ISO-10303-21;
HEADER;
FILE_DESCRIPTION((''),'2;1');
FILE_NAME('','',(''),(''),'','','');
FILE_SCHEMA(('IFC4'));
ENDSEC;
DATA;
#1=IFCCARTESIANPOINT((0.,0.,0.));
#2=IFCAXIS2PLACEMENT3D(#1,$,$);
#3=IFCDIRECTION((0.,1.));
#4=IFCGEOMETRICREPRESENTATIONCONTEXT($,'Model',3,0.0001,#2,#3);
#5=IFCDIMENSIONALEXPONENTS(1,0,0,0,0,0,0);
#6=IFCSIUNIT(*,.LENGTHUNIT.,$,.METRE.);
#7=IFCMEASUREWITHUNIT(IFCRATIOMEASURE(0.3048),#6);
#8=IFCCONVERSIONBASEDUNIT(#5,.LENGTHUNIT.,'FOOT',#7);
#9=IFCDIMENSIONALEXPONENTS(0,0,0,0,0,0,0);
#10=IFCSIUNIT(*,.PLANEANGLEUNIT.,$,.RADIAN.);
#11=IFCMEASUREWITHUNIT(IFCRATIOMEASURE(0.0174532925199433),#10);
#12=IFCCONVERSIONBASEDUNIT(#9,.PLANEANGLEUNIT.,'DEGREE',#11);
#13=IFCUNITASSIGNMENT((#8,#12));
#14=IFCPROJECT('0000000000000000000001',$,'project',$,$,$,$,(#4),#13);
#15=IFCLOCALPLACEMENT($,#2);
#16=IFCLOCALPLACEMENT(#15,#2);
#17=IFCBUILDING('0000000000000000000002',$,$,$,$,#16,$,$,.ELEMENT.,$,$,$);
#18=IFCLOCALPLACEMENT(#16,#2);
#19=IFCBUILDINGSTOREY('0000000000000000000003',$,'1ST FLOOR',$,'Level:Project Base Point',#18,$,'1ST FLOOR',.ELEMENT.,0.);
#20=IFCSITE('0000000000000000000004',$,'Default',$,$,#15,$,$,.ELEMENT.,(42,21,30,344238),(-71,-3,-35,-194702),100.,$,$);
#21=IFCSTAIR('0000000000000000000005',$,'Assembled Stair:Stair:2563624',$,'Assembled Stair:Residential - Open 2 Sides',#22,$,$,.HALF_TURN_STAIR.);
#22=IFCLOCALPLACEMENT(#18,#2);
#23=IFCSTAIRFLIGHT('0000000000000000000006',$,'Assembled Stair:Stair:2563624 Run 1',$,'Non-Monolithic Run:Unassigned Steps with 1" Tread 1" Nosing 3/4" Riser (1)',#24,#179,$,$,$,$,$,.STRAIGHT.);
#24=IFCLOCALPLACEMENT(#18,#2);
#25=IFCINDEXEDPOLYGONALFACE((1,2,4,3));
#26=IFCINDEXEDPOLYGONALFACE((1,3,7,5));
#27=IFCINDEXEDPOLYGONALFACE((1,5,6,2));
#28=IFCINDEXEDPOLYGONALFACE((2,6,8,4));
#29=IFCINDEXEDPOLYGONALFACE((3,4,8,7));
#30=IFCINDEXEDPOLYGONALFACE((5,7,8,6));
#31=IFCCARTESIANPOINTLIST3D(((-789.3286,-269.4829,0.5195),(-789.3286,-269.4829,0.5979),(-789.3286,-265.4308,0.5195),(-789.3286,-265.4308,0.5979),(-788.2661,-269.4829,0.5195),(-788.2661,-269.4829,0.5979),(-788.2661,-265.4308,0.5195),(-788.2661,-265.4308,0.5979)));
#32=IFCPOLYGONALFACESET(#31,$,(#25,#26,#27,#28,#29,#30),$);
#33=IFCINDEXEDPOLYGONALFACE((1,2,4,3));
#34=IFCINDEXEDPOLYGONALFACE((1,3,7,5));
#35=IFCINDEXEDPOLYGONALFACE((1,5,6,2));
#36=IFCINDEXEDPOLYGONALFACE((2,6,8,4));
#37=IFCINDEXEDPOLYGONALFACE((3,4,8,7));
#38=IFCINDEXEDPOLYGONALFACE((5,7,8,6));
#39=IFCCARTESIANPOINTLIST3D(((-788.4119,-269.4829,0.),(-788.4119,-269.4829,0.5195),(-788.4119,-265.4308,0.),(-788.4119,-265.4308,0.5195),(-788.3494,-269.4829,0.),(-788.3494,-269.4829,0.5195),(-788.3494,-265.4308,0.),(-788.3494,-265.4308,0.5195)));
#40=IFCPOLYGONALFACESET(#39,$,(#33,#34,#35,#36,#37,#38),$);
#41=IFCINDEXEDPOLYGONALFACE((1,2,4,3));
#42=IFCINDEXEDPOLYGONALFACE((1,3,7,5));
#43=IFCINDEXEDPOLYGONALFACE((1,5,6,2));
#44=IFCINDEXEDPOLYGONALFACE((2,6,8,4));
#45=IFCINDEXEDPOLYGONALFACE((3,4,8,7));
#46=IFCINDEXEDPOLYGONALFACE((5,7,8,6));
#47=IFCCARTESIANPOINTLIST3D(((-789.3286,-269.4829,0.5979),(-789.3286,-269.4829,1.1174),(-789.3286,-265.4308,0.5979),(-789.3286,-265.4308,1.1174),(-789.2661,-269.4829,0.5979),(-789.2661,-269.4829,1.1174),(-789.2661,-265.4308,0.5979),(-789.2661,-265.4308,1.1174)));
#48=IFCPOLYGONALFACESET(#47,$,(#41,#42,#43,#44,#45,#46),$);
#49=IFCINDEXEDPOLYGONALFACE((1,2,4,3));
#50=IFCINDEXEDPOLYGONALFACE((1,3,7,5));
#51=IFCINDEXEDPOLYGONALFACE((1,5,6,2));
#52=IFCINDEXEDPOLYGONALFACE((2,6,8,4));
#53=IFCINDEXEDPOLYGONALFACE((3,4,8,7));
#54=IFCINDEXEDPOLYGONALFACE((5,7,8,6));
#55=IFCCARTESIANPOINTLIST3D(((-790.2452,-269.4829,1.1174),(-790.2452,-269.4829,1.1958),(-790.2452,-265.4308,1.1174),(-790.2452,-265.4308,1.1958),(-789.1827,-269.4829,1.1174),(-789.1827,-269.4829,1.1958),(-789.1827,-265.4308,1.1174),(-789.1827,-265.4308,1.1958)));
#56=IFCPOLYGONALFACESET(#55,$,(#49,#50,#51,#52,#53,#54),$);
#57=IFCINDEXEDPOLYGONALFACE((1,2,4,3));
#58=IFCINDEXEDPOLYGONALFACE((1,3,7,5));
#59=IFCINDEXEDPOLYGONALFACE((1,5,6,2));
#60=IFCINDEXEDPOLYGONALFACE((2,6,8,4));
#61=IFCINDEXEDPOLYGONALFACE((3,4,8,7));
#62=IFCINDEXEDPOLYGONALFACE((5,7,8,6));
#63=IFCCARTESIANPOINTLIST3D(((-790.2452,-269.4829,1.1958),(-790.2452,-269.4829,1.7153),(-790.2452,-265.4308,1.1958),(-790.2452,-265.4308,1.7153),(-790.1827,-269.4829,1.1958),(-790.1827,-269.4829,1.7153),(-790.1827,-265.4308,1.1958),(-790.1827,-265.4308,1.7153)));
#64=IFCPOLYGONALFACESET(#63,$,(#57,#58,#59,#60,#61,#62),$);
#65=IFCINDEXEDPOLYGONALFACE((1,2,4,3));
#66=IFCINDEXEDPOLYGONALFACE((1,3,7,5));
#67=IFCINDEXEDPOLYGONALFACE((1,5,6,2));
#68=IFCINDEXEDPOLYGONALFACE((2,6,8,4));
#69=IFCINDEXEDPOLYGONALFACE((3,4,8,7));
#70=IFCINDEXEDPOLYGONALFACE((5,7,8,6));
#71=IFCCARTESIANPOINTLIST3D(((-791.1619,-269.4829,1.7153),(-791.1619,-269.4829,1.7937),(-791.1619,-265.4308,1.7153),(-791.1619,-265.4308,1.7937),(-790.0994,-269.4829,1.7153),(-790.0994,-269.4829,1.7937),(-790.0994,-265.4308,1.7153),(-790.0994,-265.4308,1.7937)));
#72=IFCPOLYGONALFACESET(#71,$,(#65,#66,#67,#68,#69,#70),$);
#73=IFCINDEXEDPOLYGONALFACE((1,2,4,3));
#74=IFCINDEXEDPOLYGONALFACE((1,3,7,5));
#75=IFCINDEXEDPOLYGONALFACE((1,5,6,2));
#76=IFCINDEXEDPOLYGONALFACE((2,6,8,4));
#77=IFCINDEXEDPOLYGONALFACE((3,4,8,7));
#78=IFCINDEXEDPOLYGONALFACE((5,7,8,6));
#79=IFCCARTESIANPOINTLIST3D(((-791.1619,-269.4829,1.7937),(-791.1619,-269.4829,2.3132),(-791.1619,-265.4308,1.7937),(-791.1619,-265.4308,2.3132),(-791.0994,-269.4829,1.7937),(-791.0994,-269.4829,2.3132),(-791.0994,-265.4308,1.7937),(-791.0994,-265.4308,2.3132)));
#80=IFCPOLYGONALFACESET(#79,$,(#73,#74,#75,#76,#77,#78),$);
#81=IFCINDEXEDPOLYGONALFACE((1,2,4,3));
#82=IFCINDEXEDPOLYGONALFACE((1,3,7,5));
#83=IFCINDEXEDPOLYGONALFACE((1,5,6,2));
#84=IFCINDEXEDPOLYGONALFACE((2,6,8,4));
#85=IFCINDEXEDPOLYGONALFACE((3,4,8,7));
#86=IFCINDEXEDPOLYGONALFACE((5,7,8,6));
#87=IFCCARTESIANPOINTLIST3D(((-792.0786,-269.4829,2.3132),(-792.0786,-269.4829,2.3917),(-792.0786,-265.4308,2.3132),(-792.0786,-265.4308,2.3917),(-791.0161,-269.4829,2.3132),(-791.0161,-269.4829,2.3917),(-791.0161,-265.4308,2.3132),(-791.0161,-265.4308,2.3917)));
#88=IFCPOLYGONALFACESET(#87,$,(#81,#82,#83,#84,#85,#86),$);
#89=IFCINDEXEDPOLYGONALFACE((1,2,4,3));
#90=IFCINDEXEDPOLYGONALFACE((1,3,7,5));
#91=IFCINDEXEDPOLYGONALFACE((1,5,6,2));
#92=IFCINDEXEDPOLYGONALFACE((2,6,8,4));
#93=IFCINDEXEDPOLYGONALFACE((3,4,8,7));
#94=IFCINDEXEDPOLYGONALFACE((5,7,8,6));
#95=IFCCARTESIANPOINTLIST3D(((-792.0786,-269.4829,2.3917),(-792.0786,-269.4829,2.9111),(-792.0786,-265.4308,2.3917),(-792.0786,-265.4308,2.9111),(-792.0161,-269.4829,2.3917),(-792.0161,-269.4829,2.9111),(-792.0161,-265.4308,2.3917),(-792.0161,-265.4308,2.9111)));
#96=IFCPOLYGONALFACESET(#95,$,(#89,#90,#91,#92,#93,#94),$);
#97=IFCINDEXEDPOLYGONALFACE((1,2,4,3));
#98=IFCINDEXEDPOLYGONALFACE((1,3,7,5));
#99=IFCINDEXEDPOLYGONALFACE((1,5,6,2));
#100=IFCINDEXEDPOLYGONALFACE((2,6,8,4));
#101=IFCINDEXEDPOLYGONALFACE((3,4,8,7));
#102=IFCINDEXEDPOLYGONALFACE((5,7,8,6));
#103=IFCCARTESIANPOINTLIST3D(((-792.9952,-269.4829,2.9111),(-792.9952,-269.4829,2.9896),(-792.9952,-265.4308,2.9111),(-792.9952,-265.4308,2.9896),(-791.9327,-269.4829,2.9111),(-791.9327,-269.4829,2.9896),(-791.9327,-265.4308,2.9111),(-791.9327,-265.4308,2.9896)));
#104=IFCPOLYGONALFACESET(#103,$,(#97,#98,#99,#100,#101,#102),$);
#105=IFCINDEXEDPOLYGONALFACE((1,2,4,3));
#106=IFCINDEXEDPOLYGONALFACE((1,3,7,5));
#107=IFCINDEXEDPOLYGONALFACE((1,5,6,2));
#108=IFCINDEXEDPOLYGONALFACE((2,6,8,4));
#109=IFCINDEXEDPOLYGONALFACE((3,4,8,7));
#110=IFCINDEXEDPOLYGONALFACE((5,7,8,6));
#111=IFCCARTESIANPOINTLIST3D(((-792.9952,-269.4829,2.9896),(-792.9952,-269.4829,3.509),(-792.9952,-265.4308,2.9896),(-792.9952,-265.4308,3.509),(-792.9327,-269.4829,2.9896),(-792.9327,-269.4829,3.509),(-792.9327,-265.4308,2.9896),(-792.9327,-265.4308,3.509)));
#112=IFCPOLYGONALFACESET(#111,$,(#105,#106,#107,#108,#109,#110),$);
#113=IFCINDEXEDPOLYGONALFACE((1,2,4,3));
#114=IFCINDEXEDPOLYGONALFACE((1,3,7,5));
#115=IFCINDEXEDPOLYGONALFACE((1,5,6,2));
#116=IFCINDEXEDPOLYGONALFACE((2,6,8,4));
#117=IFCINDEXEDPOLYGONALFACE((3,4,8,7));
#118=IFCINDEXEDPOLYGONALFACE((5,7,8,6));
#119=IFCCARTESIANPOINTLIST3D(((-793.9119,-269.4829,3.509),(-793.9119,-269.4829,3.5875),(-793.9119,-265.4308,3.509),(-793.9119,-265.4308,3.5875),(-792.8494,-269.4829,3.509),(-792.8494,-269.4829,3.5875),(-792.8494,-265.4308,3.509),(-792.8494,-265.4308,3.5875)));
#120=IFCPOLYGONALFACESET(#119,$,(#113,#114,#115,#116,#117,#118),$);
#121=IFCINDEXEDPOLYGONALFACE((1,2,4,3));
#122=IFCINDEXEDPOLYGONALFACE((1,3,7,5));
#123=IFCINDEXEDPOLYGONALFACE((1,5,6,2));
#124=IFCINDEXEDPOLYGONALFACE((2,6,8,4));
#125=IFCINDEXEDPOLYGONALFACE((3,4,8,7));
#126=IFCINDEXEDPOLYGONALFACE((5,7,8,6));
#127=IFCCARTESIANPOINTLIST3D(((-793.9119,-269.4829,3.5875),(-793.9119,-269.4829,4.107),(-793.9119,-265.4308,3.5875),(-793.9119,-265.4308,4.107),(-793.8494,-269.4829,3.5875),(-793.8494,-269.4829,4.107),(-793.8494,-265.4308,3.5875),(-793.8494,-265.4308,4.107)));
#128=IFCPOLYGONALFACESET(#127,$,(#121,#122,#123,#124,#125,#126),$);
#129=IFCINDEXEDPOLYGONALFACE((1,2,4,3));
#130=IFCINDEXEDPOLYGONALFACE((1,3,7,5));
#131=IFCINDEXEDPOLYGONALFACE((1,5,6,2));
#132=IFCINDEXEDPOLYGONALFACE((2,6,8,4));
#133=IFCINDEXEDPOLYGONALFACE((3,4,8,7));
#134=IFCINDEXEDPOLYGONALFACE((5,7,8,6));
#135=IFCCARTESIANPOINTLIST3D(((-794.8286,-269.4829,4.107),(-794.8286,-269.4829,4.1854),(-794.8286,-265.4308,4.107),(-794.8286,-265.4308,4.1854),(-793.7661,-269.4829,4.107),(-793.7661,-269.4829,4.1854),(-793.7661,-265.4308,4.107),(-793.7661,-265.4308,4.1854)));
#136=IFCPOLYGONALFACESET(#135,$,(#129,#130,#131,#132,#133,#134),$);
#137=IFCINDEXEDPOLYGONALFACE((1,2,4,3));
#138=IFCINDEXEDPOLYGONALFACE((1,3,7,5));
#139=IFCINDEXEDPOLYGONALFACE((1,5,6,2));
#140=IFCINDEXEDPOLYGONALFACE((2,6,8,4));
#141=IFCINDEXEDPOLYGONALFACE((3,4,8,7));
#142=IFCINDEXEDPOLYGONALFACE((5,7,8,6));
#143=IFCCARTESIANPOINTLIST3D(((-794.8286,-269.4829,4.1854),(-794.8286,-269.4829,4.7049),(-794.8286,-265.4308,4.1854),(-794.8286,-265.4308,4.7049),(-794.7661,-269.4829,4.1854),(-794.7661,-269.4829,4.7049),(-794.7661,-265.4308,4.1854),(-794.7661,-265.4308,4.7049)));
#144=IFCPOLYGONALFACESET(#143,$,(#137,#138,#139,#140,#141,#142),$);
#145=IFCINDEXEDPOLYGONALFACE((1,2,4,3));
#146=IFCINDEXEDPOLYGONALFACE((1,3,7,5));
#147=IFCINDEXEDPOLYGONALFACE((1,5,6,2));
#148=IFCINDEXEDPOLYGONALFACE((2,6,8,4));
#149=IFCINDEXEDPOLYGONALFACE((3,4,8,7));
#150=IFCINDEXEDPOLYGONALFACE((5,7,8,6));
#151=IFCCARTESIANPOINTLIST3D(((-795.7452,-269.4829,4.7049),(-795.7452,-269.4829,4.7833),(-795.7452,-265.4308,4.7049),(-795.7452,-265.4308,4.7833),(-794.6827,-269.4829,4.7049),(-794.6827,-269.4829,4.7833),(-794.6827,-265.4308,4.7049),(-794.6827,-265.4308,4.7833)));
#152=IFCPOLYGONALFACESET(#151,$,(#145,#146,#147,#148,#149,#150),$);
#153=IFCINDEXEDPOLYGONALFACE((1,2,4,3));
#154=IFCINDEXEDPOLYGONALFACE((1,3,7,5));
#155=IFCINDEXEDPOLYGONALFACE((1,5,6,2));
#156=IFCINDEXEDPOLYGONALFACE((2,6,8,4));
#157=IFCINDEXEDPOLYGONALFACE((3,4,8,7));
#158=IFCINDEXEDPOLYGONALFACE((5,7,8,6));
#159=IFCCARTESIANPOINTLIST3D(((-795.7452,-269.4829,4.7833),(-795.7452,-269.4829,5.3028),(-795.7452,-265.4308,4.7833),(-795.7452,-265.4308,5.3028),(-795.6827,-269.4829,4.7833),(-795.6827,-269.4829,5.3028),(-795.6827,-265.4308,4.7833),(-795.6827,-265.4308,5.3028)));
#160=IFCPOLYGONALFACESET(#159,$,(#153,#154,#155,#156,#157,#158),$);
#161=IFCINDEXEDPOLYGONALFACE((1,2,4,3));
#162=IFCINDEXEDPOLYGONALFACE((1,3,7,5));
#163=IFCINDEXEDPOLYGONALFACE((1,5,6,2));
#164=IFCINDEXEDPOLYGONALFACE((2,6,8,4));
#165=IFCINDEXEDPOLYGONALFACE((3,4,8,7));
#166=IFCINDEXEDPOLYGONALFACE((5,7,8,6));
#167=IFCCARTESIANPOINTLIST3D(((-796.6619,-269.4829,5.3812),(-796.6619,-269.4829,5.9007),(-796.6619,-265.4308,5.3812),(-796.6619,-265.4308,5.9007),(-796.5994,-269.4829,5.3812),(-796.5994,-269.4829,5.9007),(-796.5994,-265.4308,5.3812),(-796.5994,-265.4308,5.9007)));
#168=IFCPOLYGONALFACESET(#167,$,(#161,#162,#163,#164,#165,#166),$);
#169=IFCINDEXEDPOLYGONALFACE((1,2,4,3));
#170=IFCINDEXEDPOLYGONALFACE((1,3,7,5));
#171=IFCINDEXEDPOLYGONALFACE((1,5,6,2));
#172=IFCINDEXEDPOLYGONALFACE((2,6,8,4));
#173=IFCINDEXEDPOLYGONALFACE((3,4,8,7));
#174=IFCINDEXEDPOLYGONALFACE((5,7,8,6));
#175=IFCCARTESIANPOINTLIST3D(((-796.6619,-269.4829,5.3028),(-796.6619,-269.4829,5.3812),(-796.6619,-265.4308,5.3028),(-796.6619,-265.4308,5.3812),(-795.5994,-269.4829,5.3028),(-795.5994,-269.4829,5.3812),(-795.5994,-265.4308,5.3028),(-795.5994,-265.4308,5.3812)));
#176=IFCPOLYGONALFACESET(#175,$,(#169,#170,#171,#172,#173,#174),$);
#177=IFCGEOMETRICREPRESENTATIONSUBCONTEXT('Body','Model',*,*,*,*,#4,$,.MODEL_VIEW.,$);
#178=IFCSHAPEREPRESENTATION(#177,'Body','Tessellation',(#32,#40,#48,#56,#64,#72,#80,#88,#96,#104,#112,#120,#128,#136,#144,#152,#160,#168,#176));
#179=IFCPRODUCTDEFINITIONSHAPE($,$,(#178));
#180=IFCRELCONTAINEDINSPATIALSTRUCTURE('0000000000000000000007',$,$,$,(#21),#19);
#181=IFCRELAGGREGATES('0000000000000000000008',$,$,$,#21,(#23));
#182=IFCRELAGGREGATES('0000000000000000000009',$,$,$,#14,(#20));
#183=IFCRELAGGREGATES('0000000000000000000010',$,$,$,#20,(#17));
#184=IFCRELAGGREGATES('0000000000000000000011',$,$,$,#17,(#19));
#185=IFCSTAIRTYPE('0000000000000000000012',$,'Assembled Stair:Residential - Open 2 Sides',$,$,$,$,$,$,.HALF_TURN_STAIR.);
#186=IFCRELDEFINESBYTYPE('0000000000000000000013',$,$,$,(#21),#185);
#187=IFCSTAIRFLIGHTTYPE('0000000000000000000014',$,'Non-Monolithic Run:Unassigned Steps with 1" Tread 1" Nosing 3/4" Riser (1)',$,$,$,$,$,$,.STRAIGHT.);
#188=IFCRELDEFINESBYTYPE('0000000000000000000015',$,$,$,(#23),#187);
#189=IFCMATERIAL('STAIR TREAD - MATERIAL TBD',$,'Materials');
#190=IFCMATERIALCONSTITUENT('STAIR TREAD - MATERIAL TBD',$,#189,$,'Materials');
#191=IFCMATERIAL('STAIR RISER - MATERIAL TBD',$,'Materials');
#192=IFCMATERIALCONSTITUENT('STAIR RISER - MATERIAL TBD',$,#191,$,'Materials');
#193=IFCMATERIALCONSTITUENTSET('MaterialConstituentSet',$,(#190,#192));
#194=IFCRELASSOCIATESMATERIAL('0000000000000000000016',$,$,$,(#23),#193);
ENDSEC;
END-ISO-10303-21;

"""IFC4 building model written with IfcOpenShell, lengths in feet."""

from ifc_helpers import new_model, entity, si_unit, converted_unit, direction, frame, frame_2d, origin, origin_2d_with_axis, place, context, subcontext, project, spatial, rectangle, extrude, material, constituent, constituent_set, type_object, element, aggregate, save


model = new_model("IFC4")

# Units and contexts
model_context = context("Model", 3, precision=0.0001, world=origin(), true_north=direction((0.0, 1.0)))
body_context = subcontext(model_context, "Body", "Model", "MODEL_VIEW")
ifc_project = project(units=[converted_unit("LENGTHUNIT", "FOOT", entity("IfcRatioMeasure", 0.3048), si_unit("LENGTHUNIT", "METRE"), dimensions=[1, 0, 0, 0, 0, 0, 0]), converted_unit("PLANEANGLEUNIT", "DEGREE", entity("IfcRatioMeasure", 0.0174532925199433), si_unit("PLANEANGLEUNIT", "RADIAN"), dimensions=[0, 0, 0, 0, 0, 0, 0])], contexts=[model_context])

# Site, building, storey
site_placement = place(None, origin())
site = spatial("IfcSite", under=ifc_project, at=site_placement, Name="Default", CompositionType="ELEMENT", RefLatitude=(42, 21, 30, 344238), RefLongitude=(-71, -3, -35, -194702), RefElevation=100.0)
building_placement = place(site_placement, origin())
building = spatial("IfcBuilding", under=site, at=building_placement, CompositionType="ELEMENT")
storey_placement = place(building_placement, origin())
storey = spatial("IfcBuildingStorey", under=building, at=storey_placement, Name="1ST FLOOR", ObjectType="Level:Project Base Point", LongName="1ST FLOOR", CompositionType="ELEMENT", Elevation=0.0)

# Stair
stair_type_1 = type_object("IfcStairType", Name="Assembled Stair:Residential - Open 2 Sides", PredefinedType="HALF_TURN_STAIR")
stair_1_placement = place(storey_placement, origin())
stair_1 = element("IfcStair", 1, at=stair_1_placement, inside=storey, type_object=stair_type_1, Name="Assembled Stair:Stair:2563624", ObjectType="Assembled Stair:Residential - Open 2 Sides", PredefinedType="HALF_TURN_STAIR")

# Shared definitions
ifc_material_1 = material(Name="STAIR TREAD - MATERIAL TBD", Category="Materials")

# Stair flight
ifc_constituent_1 = constituent(ifc_material_1, Name="STAIR TREAD - MATERIAL TBD", Category="Materials")
ifc_material_2 = material(Name="STAIR RISER - MATERIAL TBD", Category="Materials")
ifc_constituent_2 = constituent(ifc_material_2, Name="STAIR RISER - MATERIAL TBD", Category="Materials")
ifc_constituent_set_1 = constituent_set(constituents=[ifc_constituent_1, ifc_constituent_2], Name="MaterialConstituentSet")
stair_flight_type_1 = type_object("IfcStairFlightType", Name="Non-Monolithic Run:Unassigned Steps with 1\" Tread 1\" Nosing 3/4\" Riser (1)", PredefinedType="STRAIGHT")
stair_flight_1_placement = place(stair_1_placement, frame((-796.6619, -269.4829, 0.0)))
stair_flight_1 = element("IfcStairFlight", 2, at=stair_flight_1_placement, type_object=stair_flight_type_1, material=ifc_constituent_set_1, Name="Assembled Stair:Stair:2563624 Run 1", ObjectType="Non-Monolithic Run:Unassigned Steps with 1\" Tread 1\" Nosing 3/4\" Riser (1)", PredefinedType="STRAIGHT", context=body_context, shape_type="SweptSolid", body=[
    extrude(rectangle(XDim=1.0625, YDim=4.0521, at=frame_2d((0.0, 0.0), x_axis=(1.0, 0.0))), frame((7.8646, 2.026, 0.5195)), (0.0, 0.0, 1.0), 0.0785),
    extrude(rectangle(XDim=4.0521, YDim=0.0625, at=origin_2d_with_axis()), frame((8.2813, 2.026, 0.0), z_axis=(0.0, 0.0, 1.0), x_axis=(0.0, -1.0, 0.0)), (0.0, 0.0, 1.0), 0.5195),
    extrude(rectangle(XDim=4.0521, YDim=0.0625, at=origin_2d_with_axis()), frame((7.3646, 2.026, 0.5979), z_axis=(0.0, 0.0, 1.0), x_axis=(0.0, -1.0, 0.0)), (0.0, 0.0, 1.0), 0.5195),
    extrude(rectangle(XDim=1.0625, YDim=4.0521, at=origin_2d_with_axis()), frame((6.9479, 2.026, 1.1174)), (0.0, 0.0, 1.0), 0.0785),
    extrude(rectangle(XDim=4.0521, YDim=0.0625, at=origin_2d_with_axis()), frame((6.4479, 2.026, 1.1958), z_axis=(0.0, 0.0, 1.0), x_axis=(0.0, -1.0, 0.0)), (0.0, 0.0, 1.0), 0.5195),
    extrude(rectangle(XDim=1.0625, YDim=4.0521, at=origin_2d_with_axis()), frame((6.0313, 2.026, 1.7153)), (0.0, 0.0, 1.0), 0.0785),
    extrude(rectangle(XDim=4.0521, YDim=0.0625, at=origin_2d_with_axis()), frame((5.5313, 2.026, 1.7937), z_axis=(0.0, 0.0, 1.0), x_axis=(0.0, -1.0, 0.0)), (0.0, 0.0, 1.0), 0.5195),
    extrude(rectangle(XDim=1.0625, YDim=4.0521, at=frame_2d((0.0, 0.0), x_axis=(1.0, 0.0))), frame((5.1146, 2.026, 2.3132)), (0.0, 0.0, 1.0), 0.0785),
    extrude(rectangle(XDim=4.0521, YDim=0.0625, at=origin_2d_with_axis()), frame((4.6146, 2.026, 2.3917), z_axis=(0.0, 0.0, 1.0), x_axis=(0.0, -1.0, 0.0)), (0.0, 0.0, 1.0), 0.5195),
    extrude(rectangle(XDim=1.0625, YDim=4.0521, at=frame_2d((0.0, 0.0), x_axis=(1.0, 0.0))), frame((4.1979, 2.026, 2.9111)), (0.0, 0.0, 1.0), 0.0785),
    extrude(rectangle(XDim=4.0521, YDim=0.0625, at=frame_2d((0.0, 0.0), x_axis=(1.0, 0.0))), frame((3.6979, 2.026, 2.9896), z_axis=(0.0, 0.0, 1.0), x_axis=(0.0, -1.0, 0.0)), (0.0, 0.0, 1.0), 0.5195),
    extrude(rectangle(XDim=1.0625, YDim=4.0521, at=origin_2d_with_axis()), frame((3.2813, 2.026, 3.509)), (0.0, 0.0, 1.0), 0.0785),
    extrude(rectangle(XDim=4.0521, YDim=0.0625, at=frame_2d((0.0, 0.0), x_axis=(1.0, 0.0))), frame((2.7813, 2.026, 3.5875), z_axis=(0.0, 0.0, 1.0), x_axis=(0.0, -1.0, 0.0)), (0.0, 0.0, 1.0), 0.5195),
    extrude(rectangle(XDim=1.0625, YDim=4.0521, at=origin_2d_with_axis()), frame((2.3646, 2.026, 4.107)), (0.0, 0.0, 1.0), 0.0785),
    extrude(rectangle(XDim=4.0521, YDim=0.0625, at=origin_2d_with_axis()), frame((1.8646, 2.026, 4.1854), z_axis=(0.0, 0.0, 1.0), x_axis=(0.0, -1.0, 0.0)), (0.0, 0.0, 1.0), 0.5195),
    extrude(rectangle(XDim=1.0625, YDim=4.0521, at=origin_2d_with_axis()), frame((1.4479, 2.026, 4.7049)), (0.0, 0.0, 1.0), 0.0785),
    extrude(rectangle(XDim=4.0521, YDim=0.0625, at=origin_2d_with_axis()), frame((0.9479, 2.026, 4.7833), z_axis=(0.0, 0.0, 1.0), x_axis=(0.0, -1.0, 0.0)), (0.0, 0.0, 1.0), 0.5195),
    extrude(rectangle(XDim=4.0521, YDim=0.0625, at=origin_2d_with_axis()), frame((0.0313, 2.026, 5.3812), z_axis=(0.0, 0.0, 1.0), x_axis=(0.0, -1.0, 0.0)), (0.0, 0.0, 1.0), 0.5195),
    extrude(rectangle(XDim=1.0625, YDim=4.0521, at=origin_2d_with_axis()), frame((0.5313, 2.026, 5.3028)), (0.0, 0.0, 1.0), 0.0785),
])
aggregate(stair_1, [stair_flight_1])

save(model, "model.ifc")
